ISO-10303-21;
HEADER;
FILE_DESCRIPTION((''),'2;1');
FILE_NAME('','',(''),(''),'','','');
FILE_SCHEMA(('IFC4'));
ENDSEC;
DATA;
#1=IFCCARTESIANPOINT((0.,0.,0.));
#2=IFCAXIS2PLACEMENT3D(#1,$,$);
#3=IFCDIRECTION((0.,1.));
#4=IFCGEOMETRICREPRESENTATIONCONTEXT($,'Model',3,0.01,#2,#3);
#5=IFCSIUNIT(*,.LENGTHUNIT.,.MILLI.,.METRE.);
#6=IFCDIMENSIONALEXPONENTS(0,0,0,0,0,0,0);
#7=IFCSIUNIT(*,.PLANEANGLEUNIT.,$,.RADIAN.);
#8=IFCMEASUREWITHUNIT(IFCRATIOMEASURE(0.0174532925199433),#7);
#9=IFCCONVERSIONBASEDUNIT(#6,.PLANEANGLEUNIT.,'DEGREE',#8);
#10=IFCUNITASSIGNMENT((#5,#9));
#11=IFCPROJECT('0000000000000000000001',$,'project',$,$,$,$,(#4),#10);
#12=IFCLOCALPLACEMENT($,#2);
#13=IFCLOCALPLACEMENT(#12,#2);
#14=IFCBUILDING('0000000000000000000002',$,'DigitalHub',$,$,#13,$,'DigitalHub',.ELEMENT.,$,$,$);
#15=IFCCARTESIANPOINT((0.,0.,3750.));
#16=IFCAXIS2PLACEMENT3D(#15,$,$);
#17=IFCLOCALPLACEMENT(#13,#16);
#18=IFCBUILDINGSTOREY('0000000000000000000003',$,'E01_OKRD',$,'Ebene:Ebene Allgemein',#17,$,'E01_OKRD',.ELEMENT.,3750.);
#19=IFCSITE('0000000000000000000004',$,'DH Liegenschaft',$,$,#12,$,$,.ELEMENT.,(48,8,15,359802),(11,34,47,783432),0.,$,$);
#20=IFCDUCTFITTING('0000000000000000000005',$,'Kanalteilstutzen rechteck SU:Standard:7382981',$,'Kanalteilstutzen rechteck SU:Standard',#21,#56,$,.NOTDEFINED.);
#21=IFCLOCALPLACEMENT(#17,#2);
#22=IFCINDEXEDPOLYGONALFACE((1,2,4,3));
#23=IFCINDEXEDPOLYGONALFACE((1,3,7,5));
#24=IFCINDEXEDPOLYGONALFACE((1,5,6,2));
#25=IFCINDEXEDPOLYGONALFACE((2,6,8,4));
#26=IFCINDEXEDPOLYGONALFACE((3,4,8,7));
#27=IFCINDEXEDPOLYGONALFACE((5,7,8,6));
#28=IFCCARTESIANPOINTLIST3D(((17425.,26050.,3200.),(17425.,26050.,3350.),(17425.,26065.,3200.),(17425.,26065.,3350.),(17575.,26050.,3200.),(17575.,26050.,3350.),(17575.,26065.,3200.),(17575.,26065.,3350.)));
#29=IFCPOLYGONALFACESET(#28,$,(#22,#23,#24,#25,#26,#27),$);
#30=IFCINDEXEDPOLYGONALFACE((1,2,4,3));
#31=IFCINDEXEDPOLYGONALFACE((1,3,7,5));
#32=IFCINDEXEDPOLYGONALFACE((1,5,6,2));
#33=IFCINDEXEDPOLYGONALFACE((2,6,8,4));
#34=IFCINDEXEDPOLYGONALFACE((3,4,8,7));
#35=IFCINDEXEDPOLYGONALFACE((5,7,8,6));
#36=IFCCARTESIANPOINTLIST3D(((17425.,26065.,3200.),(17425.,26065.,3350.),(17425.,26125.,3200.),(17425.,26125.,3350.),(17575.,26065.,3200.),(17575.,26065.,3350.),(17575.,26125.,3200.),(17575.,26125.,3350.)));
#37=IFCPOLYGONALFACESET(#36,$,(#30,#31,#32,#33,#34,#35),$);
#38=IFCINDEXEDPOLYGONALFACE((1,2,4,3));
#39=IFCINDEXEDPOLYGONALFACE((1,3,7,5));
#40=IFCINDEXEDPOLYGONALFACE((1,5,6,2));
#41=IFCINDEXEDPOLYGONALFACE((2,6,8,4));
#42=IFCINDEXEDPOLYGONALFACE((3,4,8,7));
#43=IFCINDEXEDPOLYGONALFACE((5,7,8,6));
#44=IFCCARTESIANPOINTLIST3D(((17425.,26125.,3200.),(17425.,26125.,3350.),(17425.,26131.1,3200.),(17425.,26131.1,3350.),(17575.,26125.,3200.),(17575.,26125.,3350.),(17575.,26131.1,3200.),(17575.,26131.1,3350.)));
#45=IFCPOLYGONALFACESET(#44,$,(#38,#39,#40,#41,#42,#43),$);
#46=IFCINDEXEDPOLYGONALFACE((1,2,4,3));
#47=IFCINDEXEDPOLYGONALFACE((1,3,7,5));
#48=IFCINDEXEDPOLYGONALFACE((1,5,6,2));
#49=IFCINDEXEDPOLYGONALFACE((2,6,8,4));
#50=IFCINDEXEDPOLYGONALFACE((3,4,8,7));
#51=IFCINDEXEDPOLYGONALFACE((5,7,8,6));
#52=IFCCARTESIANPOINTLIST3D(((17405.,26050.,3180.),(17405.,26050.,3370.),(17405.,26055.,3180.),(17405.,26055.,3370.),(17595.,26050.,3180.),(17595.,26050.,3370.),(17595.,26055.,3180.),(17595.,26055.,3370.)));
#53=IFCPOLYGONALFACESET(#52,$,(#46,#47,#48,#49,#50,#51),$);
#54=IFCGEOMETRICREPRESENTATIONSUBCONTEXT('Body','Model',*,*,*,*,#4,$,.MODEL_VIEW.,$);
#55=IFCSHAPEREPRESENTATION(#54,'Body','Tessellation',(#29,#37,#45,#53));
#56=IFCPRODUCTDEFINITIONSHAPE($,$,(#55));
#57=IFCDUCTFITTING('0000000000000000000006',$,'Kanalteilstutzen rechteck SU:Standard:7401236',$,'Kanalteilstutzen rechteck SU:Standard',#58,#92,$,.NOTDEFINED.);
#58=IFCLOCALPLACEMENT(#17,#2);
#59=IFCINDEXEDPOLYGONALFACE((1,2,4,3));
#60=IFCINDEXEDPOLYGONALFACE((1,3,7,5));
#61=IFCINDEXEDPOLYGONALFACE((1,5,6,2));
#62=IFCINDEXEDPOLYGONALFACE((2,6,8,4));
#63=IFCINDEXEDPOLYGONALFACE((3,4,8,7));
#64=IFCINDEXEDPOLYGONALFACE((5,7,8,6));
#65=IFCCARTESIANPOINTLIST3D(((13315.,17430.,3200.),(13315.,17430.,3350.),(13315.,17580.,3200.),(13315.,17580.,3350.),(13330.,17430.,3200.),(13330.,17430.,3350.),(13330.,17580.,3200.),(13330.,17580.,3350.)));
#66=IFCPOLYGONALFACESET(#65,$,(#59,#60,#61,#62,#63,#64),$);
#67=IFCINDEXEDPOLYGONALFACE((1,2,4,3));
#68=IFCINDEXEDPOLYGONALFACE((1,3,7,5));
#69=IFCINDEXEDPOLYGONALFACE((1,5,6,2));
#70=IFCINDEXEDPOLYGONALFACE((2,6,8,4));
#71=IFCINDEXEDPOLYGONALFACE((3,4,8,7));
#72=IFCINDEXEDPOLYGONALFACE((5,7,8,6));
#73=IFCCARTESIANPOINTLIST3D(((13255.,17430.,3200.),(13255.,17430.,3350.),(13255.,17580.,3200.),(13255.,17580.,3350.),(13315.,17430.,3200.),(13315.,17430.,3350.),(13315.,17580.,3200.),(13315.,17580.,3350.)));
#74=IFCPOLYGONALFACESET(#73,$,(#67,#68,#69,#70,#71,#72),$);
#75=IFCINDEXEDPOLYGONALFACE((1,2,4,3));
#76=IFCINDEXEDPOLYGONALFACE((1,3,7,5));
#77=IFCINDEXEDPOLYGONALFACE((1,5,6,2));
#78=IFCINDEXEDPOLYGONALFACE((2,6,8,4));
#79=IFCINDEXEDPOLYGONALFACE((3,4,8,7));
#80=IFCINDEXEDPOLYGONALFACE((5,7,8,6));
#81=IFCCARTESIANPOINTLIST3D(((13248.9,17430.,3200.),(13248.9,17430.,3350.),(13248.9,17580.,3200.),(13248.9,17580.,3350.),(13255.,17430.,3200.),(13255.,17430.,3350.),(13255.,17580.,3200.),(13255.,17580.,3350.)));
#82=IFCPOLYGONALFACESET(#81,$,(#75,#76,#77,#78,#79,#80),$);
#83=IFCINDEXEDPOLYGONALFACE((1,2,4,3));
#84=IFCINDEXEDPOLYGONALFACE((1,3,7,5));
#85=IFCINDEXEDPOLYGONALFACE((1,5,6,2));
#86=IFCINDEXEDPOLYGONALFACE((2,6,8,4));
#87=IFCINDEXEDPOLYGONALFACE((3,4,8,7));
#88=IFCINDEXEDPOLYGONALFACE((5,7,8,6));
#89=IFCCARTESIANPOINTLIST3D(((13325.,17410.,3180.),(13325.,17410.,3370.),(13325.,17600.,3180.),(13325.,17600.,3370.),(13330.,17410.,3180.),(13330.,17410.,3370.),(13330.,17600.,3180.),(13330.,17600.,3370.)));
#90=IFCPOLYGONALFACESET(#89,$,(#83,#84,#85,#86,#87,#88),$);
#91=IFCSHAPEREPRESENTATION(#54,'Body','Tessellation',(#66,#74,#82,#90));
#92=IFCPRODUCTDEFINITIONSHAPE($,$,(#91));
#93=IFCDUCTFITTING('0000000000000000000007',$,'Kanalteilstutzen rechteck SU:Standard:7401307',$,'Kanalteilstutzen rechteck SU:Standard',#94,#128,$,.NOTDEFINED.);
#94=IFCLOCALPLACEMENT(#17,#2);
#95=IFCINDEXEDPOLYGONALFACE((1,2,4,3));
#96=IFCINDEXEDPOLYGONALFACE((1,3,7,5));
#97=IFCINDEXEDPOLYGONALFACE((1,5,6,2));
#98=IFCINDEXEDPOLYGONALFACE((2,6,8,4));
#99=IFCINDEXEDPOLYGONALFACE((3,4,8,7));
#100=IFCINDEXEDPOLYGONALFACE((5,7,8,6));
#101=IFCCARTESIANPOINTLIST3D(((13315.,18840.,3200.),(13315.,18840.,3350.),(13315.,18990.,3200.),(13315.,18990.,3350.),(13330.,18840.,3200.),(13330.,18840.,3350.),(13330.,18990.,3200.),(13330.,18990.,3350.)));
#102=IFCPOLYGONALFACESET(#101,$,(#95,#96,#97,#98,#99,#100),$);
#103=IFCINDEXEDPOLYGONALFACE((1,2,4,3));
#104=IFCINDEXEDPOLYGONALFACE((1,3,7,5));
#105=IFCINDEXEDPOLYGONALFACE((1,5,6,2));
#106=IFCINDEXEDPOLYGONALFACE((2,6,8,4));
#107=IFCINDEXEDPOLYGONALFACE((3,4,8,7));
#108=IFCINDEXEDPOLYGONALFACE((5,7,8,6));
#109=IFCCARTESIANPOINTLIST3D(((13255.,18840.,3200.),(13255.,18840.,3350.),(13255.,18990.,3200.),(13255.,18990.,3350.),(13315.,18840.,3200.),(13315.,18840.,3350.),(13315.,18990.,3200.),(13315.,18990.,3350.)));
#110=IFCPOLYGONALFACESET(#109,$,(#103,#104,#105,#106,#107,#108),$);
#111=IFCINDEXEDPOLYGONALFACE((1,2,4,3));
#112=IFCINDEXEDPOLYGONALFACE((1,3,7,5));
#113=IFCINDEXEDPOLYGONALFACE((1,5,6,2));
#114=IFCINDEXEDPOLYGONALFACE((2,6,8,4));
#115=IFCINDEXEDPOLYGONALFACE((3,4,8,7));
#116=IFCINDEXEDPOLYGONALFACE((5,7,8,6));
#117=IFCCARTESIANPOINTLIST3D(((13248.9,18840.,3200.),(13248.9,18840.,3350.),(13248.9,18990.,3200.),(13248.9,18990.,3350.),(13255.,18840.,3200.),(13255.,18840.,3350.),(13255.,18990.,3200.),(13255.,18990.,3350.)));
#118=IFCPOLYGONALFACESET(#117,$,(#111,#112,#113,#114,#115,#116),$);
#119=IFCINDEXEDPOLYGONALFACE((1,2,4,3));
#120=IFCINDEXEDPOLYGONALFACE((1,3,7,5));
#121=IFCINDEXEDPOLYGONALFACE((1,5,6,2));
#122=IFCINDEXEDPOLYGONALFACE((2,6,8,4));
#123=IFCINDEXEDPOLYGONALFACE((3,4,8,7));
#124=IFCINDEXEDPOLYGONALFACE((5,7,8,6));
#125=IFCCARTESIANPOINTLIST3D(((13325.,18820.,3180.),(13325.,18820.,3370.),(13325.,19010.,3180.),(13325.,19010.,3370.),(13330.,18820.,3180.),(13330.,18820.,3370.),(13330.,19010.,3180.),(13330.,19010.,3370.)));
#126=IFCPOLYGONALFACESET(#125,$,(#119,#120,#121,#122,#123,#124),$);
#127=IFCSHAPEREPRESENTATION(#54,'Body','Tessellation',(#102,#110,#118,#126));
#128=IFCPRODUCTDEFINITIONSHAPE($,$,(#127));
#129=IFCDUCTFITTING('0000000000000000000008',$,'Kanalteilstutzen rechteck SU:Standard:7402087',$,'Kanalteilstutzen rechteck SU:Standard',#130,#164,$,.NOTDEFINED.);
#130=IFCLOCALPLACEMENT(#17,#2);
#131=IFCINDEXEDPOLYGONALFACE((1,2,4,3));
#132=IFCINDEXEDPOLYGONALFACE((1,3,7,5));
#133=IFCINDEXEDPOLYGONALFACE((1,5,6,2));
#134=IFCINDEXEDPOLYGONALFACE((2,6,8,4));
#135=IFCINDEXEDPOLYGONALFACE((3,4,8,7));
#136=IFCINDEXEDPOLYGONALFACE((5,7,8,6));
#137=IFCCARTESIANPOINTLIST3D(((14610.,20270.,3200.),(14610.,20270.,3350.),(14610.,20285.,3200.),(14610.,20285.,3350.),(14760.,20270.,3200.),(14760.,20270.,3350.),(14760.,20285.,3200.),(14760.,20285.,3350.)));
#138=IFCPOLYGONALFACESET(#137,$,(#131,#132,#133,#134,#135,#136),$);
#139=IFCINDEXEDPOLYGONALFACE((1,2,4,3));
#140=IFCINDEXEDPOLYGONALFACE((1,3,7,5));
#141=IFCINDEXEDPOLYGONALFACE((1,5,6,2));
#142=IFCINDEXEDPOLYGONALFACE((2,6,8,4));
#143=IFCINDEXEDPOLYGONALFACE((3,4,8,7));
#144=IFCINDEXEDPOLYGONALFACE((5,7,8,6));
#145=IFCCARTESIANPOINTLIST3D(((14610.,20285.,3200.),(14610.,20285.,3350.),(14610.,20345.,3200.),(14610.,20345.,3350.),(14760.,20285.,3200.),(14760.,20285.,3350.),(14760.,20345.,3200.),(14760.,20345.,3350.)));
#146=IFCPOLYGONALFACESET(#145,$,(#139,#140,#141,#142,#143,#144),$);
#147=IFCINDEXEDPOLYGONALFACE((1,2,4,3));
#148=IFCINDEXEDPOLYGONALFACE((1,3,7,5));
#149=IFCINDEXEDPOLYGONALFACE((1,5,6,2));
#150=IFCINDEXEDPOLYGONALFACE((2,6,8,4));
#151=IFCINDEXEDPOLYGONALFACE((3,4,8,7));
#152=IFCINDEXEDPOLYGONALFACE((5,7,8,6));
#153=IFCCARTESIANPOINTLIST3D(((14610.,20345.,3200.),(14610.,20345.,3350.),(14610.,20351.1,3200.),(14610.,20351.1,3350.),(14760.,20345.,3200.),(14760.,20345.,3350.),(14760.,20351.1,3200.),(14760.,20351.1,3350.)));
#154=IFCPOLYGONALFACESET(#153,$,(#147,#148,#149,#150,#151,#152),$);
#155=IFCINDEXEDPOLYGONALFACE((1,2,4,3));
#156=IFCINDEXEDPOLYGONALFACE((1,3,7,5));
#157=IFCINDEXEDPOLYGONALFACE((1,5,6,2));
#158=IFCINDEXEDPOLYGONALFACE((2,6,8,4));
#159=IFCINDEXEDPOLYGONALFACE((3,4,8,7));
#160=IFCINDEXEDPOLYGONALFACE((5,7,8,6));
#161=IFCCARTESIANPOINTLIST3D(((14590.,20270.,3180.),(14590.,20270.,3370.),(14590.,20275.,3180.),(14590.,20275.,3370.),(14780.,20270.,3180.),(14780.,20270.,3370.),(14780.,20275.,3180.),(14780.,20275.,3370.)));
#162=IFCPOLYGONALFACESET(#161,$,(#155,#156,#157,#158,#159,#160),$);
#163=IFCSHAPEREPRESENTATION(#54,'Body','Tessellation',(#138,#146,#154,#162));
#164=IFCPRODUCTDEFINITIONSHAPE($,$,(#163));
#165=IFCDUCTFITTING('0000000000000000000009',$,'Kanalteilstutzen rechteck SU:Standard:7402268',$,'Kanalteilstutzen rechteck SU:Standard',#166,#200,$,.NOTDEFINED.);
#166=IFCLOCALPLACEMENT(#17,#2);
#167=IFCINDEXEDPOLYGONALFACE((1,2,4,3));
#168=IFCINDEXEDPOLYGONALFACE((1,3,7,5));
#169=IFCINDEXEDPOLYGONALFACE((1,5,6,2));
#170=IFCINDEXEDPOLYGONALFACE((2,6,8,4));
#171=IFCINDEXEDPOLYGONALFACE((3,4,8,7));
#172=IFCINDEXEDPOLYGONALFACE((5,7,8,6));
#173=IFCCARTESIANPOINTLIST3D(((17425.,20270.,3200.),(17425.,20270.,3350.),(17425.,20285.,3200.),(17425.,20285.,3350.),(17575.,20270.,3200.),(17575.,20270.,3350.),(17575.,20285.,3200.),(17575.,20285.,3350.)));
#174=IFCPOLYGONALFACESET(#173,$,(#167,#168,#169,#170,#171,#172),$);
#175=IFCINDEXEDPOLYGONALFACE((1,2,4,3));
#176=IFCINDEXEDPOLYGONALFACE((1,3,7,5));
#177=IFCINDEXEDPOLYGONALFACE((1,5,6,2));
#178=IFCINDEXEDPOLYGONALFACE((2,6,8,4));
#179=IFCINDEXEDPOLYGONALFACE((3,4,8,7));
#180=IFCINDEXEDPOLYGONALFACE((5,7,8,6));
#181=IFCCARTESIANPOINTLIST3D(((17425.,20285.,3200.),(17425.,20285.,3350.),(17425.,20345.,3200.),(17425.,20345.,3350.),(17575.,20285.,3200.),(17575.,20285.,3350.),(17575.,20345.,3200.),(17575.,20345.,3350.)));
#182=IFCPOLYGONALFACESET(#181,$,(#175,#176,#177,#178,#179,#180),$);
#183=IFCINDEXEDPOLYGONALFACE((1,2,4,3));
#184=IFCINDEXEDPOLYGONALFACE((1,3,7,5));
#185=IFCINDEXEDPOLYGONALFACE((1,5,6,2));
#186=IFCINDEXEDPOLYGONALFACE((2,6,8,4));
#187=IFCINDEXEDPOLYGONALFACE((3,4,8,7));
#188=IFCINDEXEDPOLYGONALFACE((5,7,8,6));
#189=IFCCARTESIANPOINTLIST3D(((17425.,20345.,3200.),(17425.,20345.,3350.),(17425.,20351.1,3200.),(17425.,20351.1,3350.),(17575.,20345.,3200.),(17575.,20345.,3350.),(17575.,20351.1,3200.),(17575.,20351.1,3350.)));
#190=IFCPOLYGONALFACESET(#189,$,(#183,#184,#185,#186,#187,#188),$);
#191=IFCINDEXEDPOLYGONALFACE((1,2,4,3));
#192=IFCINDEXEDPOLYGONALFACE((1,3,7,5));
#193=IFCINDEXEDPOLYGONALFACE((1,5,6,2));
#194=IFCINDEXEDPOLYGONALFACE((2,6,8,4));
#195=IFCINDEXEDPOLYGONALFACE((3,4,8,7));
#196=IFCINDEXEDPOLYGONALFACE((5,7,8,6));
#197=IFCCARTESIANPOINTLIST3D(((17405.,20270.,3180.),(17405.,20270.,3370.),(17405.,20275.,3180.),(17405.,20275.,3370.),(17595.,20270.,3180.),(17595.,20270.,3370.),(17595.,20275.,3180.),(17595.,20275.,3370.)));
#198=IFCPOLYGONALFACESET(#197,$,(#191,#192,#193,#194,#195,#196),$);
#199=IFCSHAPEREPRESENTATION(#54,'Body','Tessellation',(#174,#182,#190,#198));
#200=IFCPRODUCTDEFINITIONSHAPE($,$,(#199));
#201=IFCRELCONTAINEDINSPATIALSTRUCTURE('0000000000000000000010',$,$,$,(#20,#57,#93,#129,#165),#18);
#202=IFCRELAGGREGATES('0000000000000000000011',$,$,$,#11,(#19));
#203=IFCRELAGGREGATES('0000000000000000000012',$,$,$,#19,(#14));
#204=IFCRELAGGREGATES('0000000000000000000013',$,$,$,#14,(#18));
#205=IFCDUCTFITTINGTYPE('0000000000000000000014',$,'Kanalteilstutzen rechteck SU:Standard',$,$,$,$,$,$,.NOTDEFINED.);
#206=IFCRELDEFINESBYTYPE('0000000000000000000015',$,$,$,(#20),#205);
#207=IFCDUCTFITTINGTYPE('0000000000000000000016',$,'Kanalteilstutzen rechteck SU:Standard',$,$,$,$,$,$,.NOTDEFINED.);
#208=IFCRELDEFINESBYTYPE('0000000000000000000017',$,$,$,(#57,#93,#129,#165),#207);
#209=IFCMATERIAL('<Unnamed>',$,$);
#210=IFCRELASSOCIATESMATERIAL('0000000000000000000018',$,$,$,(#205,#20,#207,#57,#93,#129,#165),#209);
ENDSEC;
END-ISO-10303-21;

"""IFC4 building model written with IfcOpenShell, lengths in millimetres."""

from ifc_helpers import new_model, entity, si_unit, converted_unit, direction, frame, origin, place, context, subcontext, project, spatial, indexed_curve, outline, extrude, source, transform, mapped, material, type_object, type_shapes, element, save


model = new_model("IFC4")

# Units and contexts
model_context = context("Model", 3, precision=0.01, world=origin(), true_north=direction((0.0, 1.0)))
body_context = subcontext(model_context, "Body", "Model", "MODEL_VIEW")
ifc_project = project(units=[si_unit("LENGTHUNIT", "METRE", prefix="MILLI"), converted_unit("PLANEANGLEUNIT", "DEGREE", entity("IfcRatioMeasure", 0.0174532925199433), si_unit("PLANEANGLEUNIT", "RADIAN"), dimensions=[0, 0, 0, 0, 0, 0, 0])], contexts=[model_context])

# Site, building, storey
site_placement = place(None, origin())
site = spatial("IfcSite", under=ifc_project, at=site_placement, Name="DH Liegenschaft", CompositionType="ELEMENT", RefLatitude=(48, 8, 15, 359802), RefLongitude=(11, 34, 47, 783432), RefElevation=0.0)
building_placement = place(site_placement, origin())
building = spatial("IfcBuilding", under=site, at=building_placement, Name="DigitalHub", LongName="DigitalHub", CompositionType="ELEMENT")
storey_placement = place(building_placement, frame((0.0, 0.0, 3750.0)))
storey = spatial("IfcBuildingStorey", under=building, at=storey_placement, Name="E01_OKRD", ObjectType="Ebene:Ebene Allgemein", LongName="E01_OKRD", CompositionType="ELEMENT", Elevation=3750.0)

# Shared definitions
ifc_material_1 = material(Name="<Unnamed>")

# Duct fittings
duct_fitting_type_1 = type_object("IfcDuctFittingType", Name="Kanalteilstutzen rechteck SU:Standard", PredefinedType="NOTDEFINED", material=ifc_material_1)
shared_shape_1 = source(origin(), body_context, "Body", "SweptSolid", [
    extrude(outline(indexed_curve([(-75.0, -7.5), (75.0, -7.5), (75.0, 7.5), (-75.0, 7.5), (-75.0, -7.5)], self_intersect=False)), frame((67.5, 0.0, -75.0), z_axis=(0.0, 0.0, 1.0), x_axis=(0.0, -1.0, 0.0)), (0.0, 0.0, 1.0), 150.0),
    extrude(outline(indexed_curve([(-75.0, -30.0), (75.0, -30.0), (75.0, 30.0), (-75.0, 30.0), (-75.0, -30.0)], self_intersect=False)), frame((30.0, 0.0, -75.0), z_axis=(0.0, 0.0, 1.0), x_axis=(0.0, -1.0, 0.0)), (0.0, 0.0, 1.0), 150.0),
    extrude(outline(indexed_curve([(-75.0, -3.0), (75.0, -3.0), (75.0, 3.0), (-75.0, 3.0), (-75.0, -3.0)], self_intersect=False)), frame((-3.0, 0.0, -75.0), z_axis=(0.0, 0.0, 1.0), x_axis=(0.0, -1.0, 0.0)), (0.0, 0.0, 1.0), 150.0),
    extrude(outline(indexed_curve([(-95.0, -2.5), (95.0, -2.5), (95.0, 2.5), (-95.0, 2.5), (-95.0, -2.5)], self_intersect=False)), frame((72.5, 0.0, -95.0), z_axis=(0.0, 0.0, 1.0), x_axis=(0.0, -1.0, 0.0)), (0.0, 0.0, 1.0), 190.0),
])
type_shapes(duct_fitting_type_1, [shared_shape_1])
duct_fitting_1_placement = place(storey_placement, frame((17500.0, 26125.0, 3275.0), z_axis=(0.0, 0.0, -1.0), x_axis=(0.0, -1.0, 0.0)))
element("IfcDuctFitting", 1, at=duct_fitting_1_placement, inside=storey, type_object=duct_fitting_type_1, material=ifc_material_1, Name="Kanalteilstutzen rechteck SU:Standard:7382981", ObjectType="Kanalteilstutzen rechteck SU:Standard", PredefinedType="NOTDEFINED", context=body_context, shape_type="MappedRepresentation", body=[
    mapped(shared_shape_1, transform((0.0, 0.0, 0.0), scale=1.0)),
])
duct_fitting_type_2 = type_object("IfcDuctFittingType", Name="Kanalteilstutzen rechteck SU:Standard", PredefinedType="NOTDEFINED", material=ifc_material_1)
shared_shape_2 = source(origin(), body_context, "Body", "SweptSolid", [
    extrude(outline(indexed_curve([(-7.5, -75.0), (7.5, -75.0), (7.5, 75.0), (-7.5, 75.0), (-7.5, -75.0)], self_intersect=False)), frame((67.5, 0.0, -75.0)), (0.0, 0.0, 1.0), 150.0),
    extrude(outline(indexed_curve([(-30.0, -75.0), (30.0, -75.0), (30.0, 75.0), (-30.0, 75.0), (-30.0, -75.0)], self_intersect=False)), frame((30.0, 0.0, -75.0)), (0.0, 0.0, 1.0), 150.0),
    extrude(outline(indexed_curve([(-3.0, -75.0), (3.0, -75.0), (3.0, 75.0), (-3.0, 75.0), (-3.0, -75.0)], self_intersect=False)), frame((-3.0, 0.0, -75.0)), (0.0, 0.0, 1.0), 150.0),
    extrude(outline(indexed_curve([(-2.5, -95.0), (2.5, -95.0), (2.5, 95.0), (-2.5, 95.0), (-2.5, -95.0)], self_intersect=False)), frame((72.5, 0.0, -95.0)), (0.0, 0.0, 1.0), 190.0),
])
type_shapes(duct_fitting_type_2, [shared_shape_2])
for number, where, z_axis, x_axis, name in (
    (2, (13255.0, 17505.0, 3275.0), (0.0, 0.0, -1.0), (1.0, 0.0, 0.0), "Kanalteilstutzen rechteck SU:Standard:7401236"),
    (3, (13255.0, 18915.0, 3275.0), (0.0, 0.0, -1.0), (1.0, 0.0, 0.0), "Kanalteilstutzen rechteck SU:Standard:7401307"),
    (4, (14685.0, 20345.0, 3275.0), (0.0, 0.0, -1.0), (0.0, -1.0, 0.0), "Kanalteilstutzen rechteck SU:Standard:7402087"),
    (5, (17500.0, 20345.0, 3275.0), (0.0, 0.0, -1.0), (0.0, -1.0, 0.0), "Kanalteilstutzen rechteck SU:Standard:7402268"),
):
    element("IfcDuctFitting", number, at=place(storey_placement, frame(where, z_axis=z_axis, x_axis=x_axis)), inside=storey, type_object=duct_fitting_type_2, material=ifc_material_1, Name=name, ObjectType="Kanalteilstutzen rechteck SU:Standard", PredefinedType="NOTDEFINED", context=body_context, shape_type="MappedRepresentation", body=[
        mapped(shared_shape_2, transform((0.0, 0.0, 0.0), scale=1.0)),
    ])

save(model, "model.ifc")
